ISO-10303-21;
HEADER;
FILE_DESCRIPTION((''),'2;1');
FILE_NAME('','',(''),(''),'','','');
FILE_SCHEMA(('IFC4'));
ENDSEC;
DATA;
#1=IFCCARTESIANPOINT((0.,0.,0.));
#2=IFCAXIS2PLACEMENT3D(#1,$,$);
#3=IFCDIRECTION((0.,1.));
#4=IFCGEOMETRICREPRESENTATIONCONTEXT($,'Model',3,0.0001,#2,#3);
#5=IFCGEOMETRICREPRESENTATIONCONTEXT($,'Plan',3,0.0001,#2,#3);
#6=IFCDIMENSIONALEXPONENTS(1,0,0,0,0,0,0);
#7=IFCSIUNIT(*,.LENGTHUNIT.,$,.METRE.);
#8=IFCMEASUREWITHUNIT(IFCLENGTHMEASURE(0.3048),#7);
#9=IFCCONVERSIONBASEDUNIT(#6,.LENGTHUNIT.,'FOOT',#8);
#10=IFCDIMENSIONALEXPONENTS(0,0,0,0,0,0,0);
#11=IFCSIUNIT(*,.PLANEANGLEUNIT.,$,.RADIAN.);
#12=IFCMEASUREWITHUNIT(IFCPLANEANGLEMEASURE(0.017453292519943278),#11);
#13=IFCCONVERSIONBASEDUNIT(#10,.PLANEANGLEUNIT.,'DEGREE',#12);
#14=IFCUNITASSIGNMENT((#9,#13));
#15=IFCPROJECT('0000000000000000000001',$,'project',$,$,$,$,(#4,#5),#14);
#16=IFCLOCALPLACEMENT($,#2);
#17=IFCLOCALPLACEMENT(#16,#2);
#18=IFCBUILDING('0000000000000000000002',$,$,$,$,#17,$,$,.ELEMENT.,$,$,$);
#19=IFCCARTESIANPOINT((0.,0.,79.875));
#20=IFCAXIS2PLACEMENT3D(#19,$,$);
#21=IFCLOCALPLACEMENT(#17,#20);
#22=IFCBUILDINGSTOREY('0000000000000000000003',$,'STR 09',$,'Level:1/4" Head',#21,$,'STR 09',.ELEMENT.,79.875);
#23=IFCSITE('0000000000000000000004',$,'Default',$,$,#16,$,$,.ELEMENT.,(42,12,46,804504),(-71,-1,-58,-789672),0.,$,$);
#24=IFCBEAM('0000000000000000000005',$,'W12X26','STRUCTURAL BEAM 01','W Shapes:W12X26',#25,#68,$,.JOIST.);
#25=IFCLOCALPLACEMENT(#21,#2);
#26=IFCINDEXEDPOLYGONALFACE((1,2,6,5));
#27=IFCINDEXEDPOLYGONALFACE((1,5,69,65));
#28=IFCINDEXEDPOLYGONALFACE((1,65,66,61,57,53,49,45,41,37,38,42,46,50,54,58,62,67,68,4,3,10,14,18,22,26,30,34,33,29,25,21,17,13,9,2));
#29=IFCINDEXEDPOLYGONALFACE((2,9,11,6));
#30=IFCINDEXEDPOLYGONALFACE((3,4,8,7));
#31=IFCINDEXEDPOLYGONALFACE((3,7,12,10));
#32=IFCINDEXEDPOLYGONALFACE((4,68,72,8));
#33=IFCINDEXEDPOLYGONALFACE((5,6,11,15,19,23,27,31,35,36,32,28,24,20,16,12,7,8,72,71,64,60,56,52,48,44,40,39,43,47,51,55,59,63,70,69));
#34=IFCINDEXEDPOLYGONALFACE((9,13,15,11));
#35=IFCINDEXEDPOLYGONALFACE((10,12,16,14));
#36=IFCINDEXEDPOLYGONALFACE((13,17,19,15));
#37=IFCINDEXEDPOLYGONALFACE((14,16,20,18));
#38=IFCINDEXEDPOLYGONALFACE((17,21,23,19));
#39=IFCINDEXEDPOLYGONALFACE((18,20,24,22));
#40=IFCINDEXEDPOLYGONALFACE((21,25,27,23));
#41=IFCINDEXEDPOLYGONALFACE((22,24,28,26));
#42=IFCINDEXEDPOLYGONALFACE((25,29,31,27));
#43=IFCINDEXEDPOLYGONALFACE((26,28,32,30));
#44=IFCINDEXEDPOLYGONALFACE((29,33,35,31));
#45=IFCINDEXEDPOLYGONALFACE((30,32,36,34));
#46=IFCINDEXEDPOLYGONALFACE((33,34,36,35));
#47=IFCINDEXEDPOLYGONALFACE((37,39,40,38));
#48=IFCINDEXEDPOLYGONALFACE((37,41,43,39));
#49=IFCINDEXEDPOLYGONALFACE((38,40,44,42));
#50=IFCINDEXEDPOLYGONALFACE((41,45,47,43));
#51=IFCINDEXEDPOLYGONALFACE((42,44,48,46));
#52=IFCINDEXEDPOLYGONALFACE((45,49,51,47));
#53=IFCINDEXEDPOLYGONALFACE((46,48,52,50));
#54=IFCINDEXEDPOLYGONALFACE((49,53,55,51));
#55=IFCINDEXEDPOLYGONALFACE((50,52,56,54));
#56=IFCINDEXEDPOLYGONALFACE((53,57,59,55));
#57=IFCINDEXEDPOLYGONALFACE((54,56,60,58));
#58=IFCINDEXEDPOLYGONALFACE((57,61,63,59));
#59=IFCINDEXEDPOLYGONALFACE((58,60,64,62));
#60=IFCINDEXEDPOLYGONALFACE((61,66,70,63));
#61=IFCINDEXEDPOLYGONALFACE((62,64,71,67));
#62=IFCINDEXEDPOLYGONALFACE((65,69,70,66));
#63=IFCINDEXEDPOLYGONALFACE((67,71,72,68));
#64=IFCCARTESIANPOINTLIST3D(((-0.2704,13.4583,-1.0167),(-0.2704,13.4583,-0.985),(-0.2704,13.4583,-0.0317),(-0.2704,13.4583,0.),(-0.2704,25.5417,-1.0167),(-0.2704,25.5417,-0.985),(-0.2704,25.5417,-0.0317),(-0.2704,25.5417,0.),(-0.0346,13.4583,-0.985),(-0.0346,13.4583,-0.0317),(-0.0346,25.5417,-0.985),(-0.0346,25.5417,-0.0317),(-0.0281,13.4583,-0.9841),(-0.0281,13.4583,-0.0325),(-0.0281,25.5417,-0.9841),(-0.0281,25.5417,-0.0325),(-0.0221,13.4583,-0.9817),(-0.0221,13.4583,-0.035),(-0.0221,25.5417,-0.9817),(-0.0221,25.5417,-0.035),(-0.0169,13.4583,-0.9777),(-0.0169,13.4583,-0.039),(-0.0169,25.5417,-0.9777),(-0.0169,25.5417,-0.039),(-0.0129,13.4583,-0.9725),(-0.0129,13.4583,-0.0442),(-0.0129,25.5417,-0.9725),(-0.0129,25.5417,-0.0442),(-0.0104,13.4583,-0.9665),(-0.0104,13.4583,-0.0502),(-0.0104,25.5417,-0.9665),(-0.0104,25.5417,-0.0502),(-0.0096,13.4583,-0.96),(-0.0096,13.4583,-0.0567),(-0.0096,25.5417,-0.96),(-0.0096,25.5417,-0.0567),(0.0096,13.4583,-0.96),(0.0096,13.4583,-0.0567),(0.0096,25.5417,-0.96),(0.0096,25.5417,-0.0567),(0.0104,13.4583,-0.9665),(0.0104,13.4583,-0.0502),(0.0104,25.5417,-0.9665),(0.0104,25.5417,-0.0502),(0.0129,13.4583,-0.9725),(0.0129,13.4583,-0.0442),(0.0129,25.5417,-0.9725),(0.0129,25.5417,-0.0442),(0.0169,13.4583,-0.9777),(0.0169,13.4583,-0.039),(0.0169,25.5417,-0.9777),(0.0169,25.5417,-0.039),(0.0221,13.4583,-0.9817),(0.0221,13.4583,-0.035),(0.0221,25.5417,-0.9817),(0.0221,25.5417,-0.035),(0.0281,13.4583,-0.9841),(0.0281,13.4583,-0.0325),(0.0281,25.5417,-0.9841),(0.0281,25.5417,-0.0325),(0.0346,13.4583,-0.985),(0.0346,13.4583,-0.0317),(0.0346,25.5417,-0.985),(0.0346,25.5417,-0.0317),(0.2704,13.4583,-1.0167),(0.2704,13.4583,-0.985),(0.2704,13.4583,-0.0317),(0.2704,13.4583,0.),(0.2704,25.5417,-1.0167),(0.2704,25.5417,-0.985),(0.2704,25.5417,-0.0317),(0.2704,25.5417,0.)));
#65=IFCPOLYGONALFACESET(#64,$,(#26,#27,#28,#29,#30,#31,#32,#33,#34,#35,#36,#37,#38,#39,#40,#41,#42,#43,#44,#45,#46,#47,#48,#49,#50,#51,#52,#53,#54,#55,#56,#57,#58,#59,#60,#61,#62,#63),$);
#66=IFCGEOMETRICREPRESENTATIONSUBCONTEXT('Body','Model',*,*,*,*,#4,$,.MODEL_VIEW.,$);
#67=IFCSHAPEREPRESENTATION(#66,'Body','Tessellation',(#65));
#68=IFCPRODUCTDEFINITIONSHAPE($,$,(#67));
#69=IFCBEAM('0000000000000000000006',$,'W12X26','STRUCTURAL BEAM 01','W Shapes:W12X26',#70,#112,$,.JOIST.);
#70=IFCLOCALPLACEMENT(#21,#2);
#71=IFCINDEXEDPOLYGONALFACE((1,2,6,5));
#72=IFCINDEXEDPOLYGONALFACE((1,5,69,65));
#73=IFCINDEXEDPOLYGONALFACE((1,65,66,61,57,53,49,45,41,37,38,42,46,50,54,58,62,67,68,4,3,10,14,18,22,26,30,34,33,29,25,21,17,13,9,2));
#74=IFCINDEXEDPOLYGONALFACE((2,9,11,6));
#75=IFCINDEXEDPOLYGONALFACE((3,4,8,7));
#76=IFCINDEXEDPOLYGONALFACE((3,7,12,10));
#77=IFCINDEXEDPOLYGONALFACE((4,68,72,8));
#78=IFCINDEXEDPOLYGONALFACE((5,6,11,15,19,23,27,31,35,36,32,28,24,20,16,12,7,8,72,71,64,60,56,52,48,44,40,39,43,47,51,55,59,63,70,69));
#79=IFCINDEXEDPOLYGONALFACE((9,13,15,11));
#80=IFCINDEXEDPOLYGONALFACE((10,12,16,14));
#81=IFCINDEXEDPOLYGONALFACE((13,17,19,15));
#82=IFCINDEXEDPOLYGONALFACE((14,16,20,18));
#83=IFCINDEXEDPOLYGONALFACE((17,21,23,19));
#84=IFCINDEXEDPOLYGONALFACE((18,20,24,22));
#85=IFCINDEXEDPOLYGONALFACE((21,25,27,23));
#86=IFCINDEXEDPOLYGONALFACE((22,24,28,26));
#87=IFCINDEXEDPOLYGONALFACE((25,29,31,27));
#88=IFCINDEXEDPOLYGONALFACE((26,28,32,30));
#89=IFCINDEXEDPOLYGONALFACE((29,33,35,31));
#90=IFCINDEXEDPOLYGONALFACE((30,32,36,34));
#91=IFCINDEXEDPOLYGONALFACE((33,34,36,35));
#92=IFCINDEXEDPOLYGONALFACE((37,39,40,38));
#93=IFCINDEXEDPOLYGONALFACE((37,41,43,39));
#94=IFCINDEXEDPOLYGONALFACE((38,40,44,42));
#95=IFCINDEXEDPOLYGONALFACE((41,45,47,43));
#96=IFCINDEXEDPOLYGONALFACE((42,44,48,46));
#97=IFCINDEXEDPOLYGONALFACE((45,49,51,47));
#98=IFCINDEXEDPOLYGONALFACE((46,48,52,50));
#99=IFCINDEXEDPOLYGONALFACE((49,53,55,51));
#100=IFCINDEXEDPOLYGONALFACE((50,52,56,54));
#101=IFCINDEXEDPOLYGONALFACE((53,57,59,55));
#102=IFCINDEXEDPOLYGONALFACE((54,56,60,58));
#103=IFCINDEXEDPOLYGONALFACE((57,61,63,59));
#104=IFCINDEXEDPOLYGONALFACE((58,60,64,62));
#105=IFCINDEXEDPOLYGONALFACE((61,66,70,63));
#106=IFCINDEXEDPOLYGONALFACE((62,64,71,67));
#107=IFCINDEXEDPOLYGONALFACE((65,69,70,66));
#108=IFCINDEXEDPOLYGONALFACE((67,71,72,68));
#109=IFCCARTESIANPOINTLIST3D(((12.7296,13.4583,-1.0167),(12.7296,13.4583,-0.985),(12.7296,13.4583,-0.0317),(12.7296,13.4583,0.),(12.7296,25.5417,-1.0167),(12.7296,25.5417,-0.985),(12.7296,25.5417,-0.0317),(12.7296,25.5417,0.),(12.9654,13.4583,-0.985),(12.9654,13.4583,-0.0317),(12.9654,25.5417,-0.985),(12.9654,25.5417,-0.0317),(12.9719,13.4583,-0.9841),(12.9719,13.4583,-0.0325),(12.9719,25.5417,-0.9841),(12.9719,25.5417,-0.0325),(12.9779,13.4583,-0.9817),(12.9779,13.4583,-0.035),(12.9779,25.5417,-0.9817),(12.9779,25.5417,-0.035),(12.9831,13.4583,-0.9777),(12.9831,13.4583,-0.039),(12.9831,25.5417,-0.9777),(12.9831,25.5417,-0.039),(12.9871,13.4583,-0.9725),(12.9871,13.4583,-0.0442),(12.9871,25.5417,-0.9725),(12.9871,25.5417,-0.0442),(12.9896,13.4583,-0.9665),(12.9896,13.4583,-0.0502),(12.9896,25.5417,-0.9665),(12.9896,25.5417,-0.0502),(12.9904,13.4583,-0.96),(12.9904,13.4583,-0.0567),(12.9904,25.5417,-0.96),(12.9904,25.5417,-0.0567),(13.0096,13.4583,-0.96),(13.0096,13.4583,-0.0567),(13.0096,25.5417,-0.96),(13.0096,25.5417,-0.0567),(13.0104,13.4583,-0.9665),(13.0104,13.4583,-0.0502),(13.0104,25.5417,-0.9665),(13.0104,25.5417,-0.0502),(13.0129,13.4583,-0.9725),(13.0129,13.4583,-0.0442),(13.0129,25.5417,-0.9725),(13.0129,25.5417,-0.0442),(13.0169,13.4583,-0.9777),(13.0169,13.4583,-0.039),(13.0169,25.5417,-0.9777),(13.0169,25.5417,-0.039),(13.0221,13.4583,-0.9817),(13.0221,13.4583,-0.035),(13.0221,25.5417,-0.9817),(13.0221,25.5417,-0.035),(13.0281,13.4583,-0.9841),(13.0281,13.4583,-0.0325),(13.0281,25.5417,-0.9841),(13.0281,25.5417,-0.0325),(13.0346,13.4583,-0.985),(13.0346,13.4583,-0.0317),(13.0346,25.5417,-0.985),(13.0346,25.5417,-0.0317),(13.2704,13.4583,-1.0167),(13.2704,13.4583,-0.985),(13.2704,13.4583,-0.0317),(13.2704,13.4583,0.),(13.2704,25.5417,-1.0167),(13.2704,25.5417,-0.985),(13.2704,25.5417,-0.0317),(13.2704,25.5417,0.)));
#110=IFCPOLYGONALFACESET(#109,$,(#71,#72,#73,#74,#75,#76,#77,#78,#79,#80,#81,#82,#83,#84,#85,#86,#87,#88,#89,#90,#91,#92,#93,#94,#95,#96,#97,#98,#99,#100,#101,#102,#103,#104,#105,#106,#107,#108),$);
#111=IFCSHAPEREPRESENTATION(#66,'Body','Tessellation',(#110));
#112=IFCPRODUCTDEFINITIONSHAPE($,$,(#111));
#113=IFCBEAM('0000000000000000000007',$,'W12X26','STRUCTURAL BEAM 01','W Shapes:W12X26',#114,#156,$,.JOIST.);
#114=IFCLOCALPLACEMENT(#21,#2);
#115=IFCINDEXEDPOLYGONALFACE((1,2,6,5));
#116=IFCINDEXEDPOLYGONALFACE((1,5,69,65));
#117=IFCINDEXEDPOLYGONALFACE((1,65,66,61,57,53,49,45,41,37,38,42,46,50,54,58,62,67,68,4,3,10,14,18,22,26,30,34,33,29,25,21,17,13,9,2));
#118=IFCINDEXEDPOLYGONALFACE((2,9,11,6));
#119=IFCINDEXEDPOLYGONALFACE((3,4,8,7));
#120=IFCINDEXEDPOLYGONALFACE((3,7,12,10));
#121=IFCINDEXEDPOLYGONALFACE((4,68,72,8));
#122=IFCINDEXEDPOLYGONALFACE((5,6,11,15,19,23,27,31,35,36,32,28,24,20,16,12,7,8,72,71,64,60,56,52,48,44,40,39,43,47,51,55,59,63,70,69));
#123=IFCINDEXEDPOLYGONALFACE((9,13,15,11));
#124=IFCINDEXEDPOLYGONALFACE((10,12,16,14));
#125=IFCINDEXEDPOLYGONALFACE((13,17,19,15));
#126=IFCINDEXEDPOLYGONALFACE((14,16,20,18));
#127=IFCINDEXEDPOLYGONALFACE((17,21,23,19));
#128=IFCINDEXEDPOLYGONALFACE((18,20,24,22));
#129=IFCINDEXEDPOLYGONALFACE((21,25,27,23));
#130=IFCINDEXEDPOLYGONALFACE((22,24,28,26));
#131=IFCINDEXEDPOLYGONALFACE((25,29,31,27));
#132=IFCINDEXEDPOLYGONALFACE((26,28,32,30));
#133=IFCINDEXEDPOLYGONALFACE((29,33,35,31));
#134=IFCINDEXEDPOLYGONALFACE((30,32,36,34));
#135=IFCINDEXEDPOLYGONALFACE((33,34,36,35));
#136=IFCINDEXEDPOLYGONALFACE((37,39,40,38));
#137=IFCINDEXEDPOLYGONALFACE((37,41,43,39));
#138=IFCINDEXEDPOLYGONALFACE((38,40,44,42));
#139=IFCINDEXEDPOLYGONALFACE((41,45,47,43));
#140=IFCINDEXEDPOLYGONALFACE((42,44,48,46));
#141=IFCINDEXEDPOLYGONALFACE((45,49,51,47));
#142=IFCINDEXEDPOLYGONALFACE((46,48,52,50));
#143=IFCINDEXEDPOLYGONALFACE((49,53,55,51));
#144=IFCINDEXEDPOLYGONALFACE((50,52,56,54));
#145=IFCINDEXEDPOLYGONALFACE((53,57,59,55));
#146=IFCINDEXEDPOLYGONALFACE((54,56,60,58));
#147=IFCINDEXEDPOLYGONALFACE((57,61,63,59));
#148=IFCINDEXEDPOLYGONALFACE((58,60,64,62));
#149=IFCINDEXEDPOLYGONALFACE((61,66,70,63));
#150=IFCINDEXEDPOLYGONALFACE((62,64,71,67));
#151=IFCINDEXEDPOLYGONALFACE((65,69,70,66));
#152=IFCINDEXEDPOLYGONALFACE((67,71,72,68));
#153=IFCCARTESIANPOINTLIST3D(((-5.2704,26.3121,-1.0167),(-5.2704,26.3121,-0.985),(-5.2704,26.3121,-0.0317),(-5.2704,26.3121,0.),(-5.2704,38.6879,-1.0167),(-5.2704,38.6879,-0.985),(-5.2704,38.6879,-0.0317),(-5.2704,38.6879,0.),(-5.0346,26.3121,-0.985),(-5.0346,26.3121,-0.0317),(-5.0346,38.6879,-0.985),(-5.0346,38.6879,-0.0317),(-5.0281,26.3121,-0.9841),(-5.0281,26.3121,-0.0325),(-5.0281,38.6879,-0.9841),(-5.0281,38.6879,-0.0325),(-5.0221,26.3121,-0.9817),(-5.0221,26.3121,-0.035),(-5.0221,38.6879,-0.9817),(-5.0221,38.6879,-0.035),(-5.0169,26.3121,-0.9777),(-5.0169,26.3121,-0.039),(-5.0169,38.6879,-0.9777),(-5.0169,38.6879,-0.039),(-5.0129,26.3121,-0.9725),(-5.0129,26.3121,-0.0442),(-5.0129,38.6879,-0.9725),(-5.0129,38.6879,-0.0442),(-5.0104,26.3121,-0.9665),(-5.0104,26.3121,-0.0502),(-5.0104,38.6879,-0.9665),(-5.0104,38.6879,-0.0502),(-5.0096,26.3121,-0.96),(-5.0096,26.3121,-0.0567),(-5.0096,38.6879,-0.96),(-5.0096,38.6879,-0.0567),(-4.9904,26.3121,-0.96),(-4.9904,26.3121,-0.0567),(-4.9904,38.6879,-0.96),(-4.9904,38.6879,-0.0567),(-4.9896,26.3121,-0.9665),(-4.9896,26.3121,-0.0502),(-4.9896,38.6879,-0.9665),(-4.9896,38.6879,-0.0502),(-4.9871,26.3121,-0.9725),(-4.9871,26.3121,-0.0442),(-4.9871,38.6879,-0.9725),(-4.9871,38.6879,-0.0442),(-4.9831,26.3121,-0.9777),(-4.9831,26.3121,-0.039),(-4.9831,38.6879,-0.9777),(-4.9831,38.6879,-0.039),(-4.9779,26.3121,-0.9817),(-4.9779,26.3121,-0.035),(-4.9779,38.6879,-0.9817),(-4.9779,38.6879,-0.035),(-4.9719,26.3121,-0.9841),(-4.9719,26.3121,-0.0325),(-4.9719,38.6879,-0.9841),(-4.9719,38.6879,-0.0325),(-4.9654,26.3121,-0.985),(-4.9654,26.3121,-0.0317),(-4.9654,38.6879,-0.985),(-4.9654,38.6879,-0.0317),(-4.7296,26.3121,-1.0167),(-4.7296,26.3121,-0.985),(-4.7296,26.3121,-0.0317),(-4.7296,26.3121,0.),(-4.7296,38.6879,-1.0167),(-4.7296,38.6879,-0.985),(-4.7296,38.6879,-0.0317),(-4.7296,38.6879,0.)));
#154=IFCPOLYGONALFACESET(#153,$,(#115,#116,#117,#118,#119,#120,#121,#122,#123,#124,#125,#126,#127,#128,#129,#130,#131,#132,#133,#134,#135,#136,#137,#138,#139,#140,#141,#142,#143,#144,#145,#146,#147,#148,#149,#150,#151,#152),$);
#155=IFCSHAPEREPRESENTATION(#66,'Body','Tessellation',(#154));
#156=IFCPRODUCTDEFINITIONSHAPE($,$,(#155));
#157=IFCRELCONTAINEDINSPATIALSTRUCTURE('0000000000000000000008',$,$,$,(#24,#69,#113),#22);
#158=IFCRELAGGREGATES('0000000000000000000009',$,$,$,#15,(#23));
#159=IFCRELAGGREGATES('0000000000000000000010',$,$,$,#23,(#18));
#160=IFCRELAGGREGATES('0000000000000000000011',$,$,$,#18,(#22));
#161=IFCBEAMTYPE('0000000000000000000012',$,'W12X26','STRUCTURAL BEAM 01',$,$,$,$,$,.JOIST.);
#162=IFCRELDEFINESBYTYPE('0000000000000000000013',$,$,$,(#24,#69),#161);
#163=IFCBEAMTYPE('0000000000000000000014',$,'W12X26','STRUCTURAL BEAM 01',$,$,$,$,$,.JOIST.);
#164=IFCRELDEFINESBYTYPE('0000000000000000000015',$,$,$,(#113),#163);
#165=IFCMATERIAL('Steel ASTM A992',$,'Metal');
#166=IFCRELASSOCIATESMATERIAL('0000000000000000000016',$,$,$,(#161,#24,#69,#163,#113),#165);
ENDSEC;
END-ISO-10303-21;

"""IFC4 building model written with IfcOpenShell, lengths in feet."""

from ifc_helpers import new_model, entity, si_unit, converted_unit, direction, frame, origin, place, context, subcontext, project, spatial, line, arc, indexed_curve, outline, extrude, source, transform, mapped, material, type_object, type_shapes, element, save


model = new_model("IFC4")

# Units and contexts
model_context = context("Model", 3, precision=0.0001, world=origin(), true_north=direction((0.0, 1.0)))
plan_context = context("Plan", 3, precision=0.0001, world=origin(), true_north=direction((0.0, 1.0)))
body_context = subcontext(model_context, "Body", "Model", "MODEL_VIEW")
ifc_project = project(units=[converted_unit("LENGTHUNIT", "FOOT", entity("IfcLengthMeasure", 0.3048), si_unit("LENGTHUNIT", "METRE"), dimensions=[1, 0, 0, 0, 0, 0, 0]), converted_unit("PLANEANGLEUNIT", "DEGREE", entity("IfcPlaneAngleMeasure", 0.017453292519943278), si_unit("PLANEANGLEUNIT", "RADIAN"), dimensions=[0, 0, 0, 0, 0, 0, 0])], contexts=[model_context, plan_context])

# Site, building, storey
site_placement = place(None, origin())
site = spatial("IfcSite", under=ifc_project, at=site_placement, Name="Default", CompositionType="ELEMENT", RefLatitude=(42, 12, 46, 804504), RefLongitude=(-71, -1, -58, -789672), RefElevation=0.0)
building_placement = place(site_placement, origin())
building = spatial("IfcBuilding", under=site, at=building_placement, CompositionType="ELEMENT")
storey_placement = place(building_placement, frame((0.0, 0.0, 79.875)))
storey = spatial("IfcBuildingStorey", under=building, at=storey_placement, Name="STR 09", ObjectType="Level:1/4\" Head", LongName="STR 09", CompositionType="ELEMENT", Elevation=79.875)

# Beams
ifc_material = material(Name="Steel ASTM A992", Category="Metal")
beam_type_1 = type_object("IfcBeamType", Name="W12X26", Description="STRUCTURAL BEAM 01", PredefinedType="JOIST", material=ifc_material)
shared_shape_1 = source(origin(), body_context, "Body", "SweptSolid", [
    extrude(outline(indexed_curve([(-0.2704, -0.4767), (-0.2704, -0.5083), (0.2704, -0.5083), (0.2704, -0.4767), (0.0346, -0.4767), (0.0169, -0.4693), (0.0096, -0.4517), (0.0096, 0.4517), (0.0169, 0.4693), (0.0346, 0.4767), (0.2704, 0.4767), (0.2704, 0.5083), (-0.2704, 0.5083), (-0.2704, 0.4767), (-0.0346, 0.4767), (-0.0169, 0.4693), (-0.0096, 0.4517), (-0.0096, -0.4517), (-0.0169, -0.4693), (-0.0346, -0.4767)], segments=[line(1, 2, 3, 4, 5), arc(5, 6, 7), line(7, 8), arc(8, 9, 10), line(10, 11, 12, 13, 14, 15), arc(15, 16, 17), line(17, 18), arc(18, 19, 20), line(20, 1)], self_intersect=False)), frame((-6.2267, 0.0, 0.0), z_axis=(-1.0, 0.0, 0.0), x_axis=(0.0, -1.0, 0.0)), (0.0, 0.0, -1.0), 12.0833),
])
type_shapes(beam_type_1, [shared_shape_1])
for number, where, z_axis, x_axis, name in (
    (1, (0.0, 19.685, -0.5083), (0.0, 0.0, 1.0), (0.0, 1.0, 0.0), "W12X26"),
    (2, (13.0, 19.685, -0.5083), (0.0, 0.0, 1.0), (0.0, 1.0, 0.0), "W12X26"),
):
    element("IfcBeam", number, at=place(storey_placement, frame(where, z_axis=z_axis, x_axis=x_axis)), inside=storey, type_object=beam_type_1, material=ifc_material, Name=name, Description="STRUCTURAL BEAM 01", ObjectType="W Shapes:W12X26", PredefinedType="JOIST", context=body_context, shape_type="MappedRepresentation", body=[
        mapped(shared_shape_1, transform((0.0, 0.0, 0.0), scale=1.0)),
    ])
beam_type_2 = type_object("IfcBeamType", Name="W12X26", Description="STRUCTURAL BEAM 01", PredefinedType="JOIST", material=ifc_material)
shared_shape_2 = source(origin(), body_context, "Body", "SweptSolid", [
    extrude(outline(indexed_curve([(-0.2704, -0.4767), (-0.2704, -0.5083), (0.2704, -0.5083), (0.2704, -0.4767), (0.0346, -0.4767), (0.0169, -0.4693), (0.0096, -0.4517), (0.0096, 0.4517), (0.0169, 0.4693), (0.0346, 0.4767), (0.2704, 0.4767), (0.2704, 0.5083), (-0.2704, 0.5083), (-0.2704, 0.4767), (-0.0346, 0.4767), (-0.0169, 0.4693), (-0.0096, 0.4517), (-0.0096, -0.4517), (-0.0169, -0.4693), (-0.0346, -0.4767)], segments=[line(1, 2, 3, 4, 5), arc(5, 6, 7), line(7, 8), arc(8, 9, 10), line(10, 11, 12, 13, 14, 15), arc(15, 16, 17), line(17, 18), arc(18, 19, 20), line(20, 1)], self_intersect=False)), frame((-6.1879, 0.0, 0.0), z_axis=(-1.0, 0.0, 0.0), x_axis=(0.0, -1.0, 0.0)), (0.0, 0.0, -1.0), 12.3758),
])
type_shapes(beam_type_2, [shared_shape_2])
for number, where, z_axis, x_axis, name in (
    (3, (-5.0, 32.5, -0.5083), (0.0, 0.0, 1.0), (0.0, 1.0, 0.0), "W12X26"),
):
    element("IfcBeam", number, at=place(storey_placement, frame(where, z_axis=z_axis, x_axis=x_axis)), inside=storey, type_object=beam_type_2, material=ifc_material, Name=name, Description="STRUCTURAL BEAM 01", ObjectType="W Shapes:W12X26", PredefinedType="JOIST", context=body_context, shape_type="MappedRepresentation", body=[
        mapped(shared_shape_2, transform((0.0, 0.0, 0.0), scale=1.0)),
    ])

save(model, "model.ifc")
